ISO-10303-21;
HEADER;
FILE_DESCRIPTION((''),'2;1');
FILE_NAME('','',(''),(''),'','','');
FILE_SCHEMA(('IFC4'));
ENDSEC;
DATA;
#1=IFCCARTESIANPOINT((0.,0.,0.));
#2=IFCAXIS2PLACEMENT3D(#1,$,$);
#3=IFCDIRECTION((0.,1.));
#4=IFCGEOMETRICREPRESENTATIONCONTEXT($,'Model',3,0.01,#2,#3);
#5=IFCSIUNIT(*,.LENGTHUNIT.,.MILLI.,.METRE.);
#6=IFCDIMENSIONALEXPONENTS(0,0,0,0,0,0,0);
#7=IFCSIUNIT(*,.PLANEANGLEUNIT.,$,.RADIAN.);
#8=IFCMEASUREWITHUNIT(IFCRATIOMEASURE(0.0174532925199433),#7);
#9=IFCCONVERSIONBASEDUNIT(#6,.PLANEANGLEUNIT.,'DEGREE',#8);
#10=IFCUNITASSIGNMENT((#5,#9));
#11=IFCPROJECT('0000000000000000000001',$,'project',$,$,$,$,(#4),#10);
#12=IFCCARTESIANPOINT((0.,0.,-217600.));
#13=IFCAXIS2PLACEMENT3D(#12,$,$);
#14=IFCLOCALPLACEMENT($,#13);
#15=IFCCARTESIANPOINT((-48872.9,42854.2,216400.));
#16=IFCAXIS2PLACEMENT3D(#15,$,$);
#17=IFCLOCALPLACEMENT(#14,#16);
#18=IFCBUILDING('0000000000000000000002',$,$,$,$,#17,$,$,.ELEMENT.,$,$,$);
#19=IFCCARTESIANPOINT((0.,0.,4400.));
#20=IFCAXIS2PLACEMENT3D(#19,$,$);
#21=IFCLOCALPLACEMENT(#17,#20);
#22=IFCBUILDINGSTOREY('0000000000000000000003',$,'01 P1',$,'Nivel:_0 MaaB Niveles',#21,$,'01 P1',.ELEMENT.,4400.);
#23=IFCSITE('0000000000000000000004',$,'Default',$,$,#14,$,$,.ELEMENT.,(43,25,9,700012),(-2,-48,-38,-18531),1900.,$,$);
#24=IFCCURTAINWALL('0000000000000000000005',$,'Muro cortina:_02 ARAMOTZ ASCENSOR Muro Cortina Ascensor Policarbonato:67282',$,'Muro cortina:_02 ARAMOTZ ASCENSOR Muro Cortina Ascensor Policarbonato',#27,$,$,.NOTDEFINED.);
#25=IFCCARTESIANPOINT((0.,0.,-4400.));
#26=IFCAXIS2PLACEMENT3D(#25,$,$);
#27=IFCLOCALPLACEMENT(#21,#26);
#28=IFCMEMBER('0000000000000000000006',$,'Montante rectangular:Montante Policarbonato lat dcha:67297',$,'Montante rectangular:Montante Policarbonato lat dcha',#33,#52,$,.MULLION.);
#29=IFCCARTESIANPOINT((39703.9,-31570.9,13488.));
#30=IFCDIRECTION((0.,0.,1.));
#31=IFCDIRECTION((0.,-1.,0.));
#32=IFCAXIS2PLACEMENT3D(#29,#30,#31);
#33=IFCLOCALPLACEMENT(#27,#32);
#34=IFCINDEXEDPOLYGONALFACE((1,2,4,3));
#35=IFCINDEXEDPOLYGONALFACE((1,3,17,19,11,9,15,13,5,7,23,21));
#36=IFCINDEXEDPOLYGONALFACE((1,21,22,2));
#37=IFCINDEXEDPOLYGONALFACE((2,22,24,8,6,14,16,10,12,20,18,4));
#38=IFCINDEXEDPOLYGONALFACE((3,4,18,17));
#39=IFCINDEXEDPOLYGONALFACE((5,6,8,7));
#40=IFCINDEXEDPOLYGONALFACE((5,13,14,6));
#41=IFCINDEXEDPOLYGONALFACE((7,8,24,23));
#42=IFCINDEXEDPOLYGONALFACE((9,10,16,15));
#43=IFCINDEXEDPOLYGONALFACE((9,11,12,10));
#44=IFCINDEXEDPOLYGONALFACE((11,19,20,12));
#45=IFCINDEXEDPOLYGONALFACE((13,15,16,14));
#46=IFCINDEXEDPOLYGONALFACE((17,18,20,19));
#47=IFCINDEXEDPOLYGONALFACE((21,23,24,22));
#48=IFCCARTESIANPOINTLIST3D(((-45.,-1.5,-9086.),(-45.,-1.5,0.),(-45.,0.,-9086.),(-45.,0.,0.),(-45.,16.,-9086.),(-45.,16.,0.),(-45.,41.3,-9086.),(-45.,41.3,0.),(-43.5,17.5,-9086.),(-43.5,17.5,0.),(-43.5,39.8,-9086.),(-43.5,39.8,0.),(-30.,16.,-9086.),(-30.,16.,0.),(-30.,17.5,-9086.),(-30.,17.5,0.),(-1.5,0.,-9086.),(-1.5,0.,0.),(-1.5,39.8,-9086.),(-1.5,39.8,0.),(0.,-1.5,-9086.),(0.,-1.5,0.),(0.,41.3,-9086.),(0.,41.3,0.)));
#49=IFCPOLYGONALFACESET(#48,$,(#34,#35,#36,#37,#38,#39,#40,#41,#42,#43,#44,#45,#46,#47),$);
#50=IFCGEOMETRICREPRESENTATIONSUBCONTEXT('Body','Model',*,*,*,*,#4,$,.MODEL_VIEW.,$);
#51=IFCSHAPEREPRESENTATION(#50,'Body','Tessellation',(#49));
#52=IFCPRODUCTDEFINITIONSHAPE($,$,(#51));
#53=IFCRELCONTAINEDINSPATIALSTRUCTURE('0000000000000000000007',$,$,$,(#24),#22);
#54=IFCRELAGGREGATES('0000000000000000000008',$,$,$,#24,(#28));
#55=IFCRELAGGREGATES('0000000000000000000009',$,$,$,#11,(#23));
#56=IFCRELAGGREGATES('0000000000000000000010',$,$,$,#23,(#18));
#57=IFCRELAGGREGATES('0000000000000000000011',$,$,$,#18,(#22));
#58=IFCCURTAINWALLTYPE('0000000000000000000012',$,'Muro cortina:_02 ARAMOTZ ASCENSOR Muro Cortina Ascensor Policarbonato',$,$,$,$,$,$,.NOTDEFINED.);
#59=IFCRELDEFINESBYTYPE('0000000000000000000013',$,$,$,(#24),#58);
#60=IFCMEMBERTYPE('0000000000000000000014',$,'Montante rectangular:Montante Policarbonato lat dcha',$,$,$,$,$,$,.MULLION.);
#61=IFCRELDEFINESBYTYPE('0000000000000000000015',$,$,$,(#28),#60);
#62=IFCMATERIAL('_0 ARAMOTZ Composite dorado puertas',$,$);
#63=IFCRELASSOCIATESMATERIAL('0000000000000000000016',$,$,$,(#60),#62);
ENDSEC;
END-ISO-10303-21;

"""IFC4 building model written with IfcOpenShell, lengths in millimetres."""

from ifc_helpers import new_model, entity, si_unit, converted_unit, direction, frame, origin, place, context, subcontext, project, spatial, indexed_curve, outline, extrude, source, transform, mapped, material, type_object, type_shapes, element, aggregate, save


model = new_model("IFC4")

# Units and contexts
model_context = context("Model", 3, precision=0.01, world=origin(), true_north=direction((0.0, 1.0)))
body_context = subcontext(model_context, "Body", "Model", "MODEL_VIEW")
ifc_project = project(units=[si_unit("LENGTHUNIT", "METRE", prefix="MILLI"), converted_unit("PLANEANGLEUNIT", "DEGREE", entity("IfcRatioMeasure", 0.0174532925199433), si_unit("PLANEANGLEUNIT", "RADIAN"), dimensions=[0, 0, 0, 0, 0, 0, 0])], contexts=[model_context])

# Site, building, storey
site_placement = place(None, frame((0.0, 0.0, -217600.0)))
site = spatial("IfcSite", under=ifc_project, at=site_placement, Name="Default", CompositionType="ELEMENT", RefLatitude=(43, 25, 9, 700012), RefLongitude=(-2, -48, -38, -18531), RefElevation=1900.0)
building_placement = place(site_placement, frame((-48872.9, 42854.2, 216400.0)))
building = spatial("IfcBuilding", under=site, at=building_placement, CompositionType="ELEMENT")
storey_placement = place(building_placement, frame((0.0, 0.0, 4400.0)))
storey = spatial("IfcBuildingStorey", under=building, at=storey_placement, Name="01 P1", ObjectType="Nivel:_0 MaaB Niveles", LongName="01 P1", CompositionType="ELEMENT", Elevation=4400.0)

# Shared definitions
curtain_wall_type_1 = type_object("IfcCurtainWallType", Name="Muro cortina:_02 ARAMOTZ ASCENSOR Muro Cortina Ascensor Policarbonato", PredefinedType="NOTDEFINED")

# Curtain wall, member
curtain_wall_1_placement = place(storey_placement, frame((0.0, 0.0, -4400.0)))
curtain_wall_1 = element("IfcCurtainWall", 1, at=curtain_wall_1_placement, inside=storey, type_object=curtain_wall_type_1, Name="Muro cortina:_02 ARAMOTZ ASCENSOR Muro Cortina Ascensor Policarbonato:67282", ObjectType="Muro cortina:_02 ARAMOTZ ASCENSOR Muro Cortina Ascensor Policarbonato", PredefinedType="NOTDEFINED")
ifc_material_1 = material(Name="_0 ARAMOTZ Composite dorado puertas")
member_type_1 = type_object("IfcMemberType", Name="Montante rectangular:Montante Policarbonato lat dcha", PredefinedType="MULLION", material=ifc_material_1)
shared_shape_1 = source(origin(), body_context, "Body", "SweptSolid", [
    extrude(outline(indexed_curve([(18.9, -17.5), (20.4, -17.5), (20.4, 27.5), (-22.5, 27.5), (-22.5, -17.5), (2.9, -17.5), (2.9, -2.5), (1.4, -2.5), (1.4, -16.0), (-21.0, -16.0), (-21.0, 26.0), (18.9, 26.0), (18.9, -17.5)], self_intersect=False)), frame((-27.5, 18.9, -9086.0), z_axis=(0.0, 0.0, 1.0), x_axis=(0.0, -1.0, 0.0)), (0.0, 0.0, 1.0), 9086.0),
])
type_shapes(member_type_1, [shared_shape_1])
member_1_placement = place(curtain_wall_1_placement, frame((39703.9, -31570.9, 13488.0), z_axis=(0.0, 0.0, 1.0), x_axis=(0.0, -1.0, 0.0)))
member_1 = element("IfcMember", 2, at=member_1_placement, type_object=member_type_1, Name="Montante rectangular:Montante Policarbonato lat dcha:67297", ObjectType="Montante rectangular:Montante Policarbonato lat dcha", PredefinedType="MULLION", context=body_context, shape_type="MappedRepresentation", body=[
    mapped(shared_shape_1, transform((0.0, 0.0, 0.0), scale=1.0)),
])

aggregate(curtain_wall_1, [member_1])

save(model, "model.ifc")
